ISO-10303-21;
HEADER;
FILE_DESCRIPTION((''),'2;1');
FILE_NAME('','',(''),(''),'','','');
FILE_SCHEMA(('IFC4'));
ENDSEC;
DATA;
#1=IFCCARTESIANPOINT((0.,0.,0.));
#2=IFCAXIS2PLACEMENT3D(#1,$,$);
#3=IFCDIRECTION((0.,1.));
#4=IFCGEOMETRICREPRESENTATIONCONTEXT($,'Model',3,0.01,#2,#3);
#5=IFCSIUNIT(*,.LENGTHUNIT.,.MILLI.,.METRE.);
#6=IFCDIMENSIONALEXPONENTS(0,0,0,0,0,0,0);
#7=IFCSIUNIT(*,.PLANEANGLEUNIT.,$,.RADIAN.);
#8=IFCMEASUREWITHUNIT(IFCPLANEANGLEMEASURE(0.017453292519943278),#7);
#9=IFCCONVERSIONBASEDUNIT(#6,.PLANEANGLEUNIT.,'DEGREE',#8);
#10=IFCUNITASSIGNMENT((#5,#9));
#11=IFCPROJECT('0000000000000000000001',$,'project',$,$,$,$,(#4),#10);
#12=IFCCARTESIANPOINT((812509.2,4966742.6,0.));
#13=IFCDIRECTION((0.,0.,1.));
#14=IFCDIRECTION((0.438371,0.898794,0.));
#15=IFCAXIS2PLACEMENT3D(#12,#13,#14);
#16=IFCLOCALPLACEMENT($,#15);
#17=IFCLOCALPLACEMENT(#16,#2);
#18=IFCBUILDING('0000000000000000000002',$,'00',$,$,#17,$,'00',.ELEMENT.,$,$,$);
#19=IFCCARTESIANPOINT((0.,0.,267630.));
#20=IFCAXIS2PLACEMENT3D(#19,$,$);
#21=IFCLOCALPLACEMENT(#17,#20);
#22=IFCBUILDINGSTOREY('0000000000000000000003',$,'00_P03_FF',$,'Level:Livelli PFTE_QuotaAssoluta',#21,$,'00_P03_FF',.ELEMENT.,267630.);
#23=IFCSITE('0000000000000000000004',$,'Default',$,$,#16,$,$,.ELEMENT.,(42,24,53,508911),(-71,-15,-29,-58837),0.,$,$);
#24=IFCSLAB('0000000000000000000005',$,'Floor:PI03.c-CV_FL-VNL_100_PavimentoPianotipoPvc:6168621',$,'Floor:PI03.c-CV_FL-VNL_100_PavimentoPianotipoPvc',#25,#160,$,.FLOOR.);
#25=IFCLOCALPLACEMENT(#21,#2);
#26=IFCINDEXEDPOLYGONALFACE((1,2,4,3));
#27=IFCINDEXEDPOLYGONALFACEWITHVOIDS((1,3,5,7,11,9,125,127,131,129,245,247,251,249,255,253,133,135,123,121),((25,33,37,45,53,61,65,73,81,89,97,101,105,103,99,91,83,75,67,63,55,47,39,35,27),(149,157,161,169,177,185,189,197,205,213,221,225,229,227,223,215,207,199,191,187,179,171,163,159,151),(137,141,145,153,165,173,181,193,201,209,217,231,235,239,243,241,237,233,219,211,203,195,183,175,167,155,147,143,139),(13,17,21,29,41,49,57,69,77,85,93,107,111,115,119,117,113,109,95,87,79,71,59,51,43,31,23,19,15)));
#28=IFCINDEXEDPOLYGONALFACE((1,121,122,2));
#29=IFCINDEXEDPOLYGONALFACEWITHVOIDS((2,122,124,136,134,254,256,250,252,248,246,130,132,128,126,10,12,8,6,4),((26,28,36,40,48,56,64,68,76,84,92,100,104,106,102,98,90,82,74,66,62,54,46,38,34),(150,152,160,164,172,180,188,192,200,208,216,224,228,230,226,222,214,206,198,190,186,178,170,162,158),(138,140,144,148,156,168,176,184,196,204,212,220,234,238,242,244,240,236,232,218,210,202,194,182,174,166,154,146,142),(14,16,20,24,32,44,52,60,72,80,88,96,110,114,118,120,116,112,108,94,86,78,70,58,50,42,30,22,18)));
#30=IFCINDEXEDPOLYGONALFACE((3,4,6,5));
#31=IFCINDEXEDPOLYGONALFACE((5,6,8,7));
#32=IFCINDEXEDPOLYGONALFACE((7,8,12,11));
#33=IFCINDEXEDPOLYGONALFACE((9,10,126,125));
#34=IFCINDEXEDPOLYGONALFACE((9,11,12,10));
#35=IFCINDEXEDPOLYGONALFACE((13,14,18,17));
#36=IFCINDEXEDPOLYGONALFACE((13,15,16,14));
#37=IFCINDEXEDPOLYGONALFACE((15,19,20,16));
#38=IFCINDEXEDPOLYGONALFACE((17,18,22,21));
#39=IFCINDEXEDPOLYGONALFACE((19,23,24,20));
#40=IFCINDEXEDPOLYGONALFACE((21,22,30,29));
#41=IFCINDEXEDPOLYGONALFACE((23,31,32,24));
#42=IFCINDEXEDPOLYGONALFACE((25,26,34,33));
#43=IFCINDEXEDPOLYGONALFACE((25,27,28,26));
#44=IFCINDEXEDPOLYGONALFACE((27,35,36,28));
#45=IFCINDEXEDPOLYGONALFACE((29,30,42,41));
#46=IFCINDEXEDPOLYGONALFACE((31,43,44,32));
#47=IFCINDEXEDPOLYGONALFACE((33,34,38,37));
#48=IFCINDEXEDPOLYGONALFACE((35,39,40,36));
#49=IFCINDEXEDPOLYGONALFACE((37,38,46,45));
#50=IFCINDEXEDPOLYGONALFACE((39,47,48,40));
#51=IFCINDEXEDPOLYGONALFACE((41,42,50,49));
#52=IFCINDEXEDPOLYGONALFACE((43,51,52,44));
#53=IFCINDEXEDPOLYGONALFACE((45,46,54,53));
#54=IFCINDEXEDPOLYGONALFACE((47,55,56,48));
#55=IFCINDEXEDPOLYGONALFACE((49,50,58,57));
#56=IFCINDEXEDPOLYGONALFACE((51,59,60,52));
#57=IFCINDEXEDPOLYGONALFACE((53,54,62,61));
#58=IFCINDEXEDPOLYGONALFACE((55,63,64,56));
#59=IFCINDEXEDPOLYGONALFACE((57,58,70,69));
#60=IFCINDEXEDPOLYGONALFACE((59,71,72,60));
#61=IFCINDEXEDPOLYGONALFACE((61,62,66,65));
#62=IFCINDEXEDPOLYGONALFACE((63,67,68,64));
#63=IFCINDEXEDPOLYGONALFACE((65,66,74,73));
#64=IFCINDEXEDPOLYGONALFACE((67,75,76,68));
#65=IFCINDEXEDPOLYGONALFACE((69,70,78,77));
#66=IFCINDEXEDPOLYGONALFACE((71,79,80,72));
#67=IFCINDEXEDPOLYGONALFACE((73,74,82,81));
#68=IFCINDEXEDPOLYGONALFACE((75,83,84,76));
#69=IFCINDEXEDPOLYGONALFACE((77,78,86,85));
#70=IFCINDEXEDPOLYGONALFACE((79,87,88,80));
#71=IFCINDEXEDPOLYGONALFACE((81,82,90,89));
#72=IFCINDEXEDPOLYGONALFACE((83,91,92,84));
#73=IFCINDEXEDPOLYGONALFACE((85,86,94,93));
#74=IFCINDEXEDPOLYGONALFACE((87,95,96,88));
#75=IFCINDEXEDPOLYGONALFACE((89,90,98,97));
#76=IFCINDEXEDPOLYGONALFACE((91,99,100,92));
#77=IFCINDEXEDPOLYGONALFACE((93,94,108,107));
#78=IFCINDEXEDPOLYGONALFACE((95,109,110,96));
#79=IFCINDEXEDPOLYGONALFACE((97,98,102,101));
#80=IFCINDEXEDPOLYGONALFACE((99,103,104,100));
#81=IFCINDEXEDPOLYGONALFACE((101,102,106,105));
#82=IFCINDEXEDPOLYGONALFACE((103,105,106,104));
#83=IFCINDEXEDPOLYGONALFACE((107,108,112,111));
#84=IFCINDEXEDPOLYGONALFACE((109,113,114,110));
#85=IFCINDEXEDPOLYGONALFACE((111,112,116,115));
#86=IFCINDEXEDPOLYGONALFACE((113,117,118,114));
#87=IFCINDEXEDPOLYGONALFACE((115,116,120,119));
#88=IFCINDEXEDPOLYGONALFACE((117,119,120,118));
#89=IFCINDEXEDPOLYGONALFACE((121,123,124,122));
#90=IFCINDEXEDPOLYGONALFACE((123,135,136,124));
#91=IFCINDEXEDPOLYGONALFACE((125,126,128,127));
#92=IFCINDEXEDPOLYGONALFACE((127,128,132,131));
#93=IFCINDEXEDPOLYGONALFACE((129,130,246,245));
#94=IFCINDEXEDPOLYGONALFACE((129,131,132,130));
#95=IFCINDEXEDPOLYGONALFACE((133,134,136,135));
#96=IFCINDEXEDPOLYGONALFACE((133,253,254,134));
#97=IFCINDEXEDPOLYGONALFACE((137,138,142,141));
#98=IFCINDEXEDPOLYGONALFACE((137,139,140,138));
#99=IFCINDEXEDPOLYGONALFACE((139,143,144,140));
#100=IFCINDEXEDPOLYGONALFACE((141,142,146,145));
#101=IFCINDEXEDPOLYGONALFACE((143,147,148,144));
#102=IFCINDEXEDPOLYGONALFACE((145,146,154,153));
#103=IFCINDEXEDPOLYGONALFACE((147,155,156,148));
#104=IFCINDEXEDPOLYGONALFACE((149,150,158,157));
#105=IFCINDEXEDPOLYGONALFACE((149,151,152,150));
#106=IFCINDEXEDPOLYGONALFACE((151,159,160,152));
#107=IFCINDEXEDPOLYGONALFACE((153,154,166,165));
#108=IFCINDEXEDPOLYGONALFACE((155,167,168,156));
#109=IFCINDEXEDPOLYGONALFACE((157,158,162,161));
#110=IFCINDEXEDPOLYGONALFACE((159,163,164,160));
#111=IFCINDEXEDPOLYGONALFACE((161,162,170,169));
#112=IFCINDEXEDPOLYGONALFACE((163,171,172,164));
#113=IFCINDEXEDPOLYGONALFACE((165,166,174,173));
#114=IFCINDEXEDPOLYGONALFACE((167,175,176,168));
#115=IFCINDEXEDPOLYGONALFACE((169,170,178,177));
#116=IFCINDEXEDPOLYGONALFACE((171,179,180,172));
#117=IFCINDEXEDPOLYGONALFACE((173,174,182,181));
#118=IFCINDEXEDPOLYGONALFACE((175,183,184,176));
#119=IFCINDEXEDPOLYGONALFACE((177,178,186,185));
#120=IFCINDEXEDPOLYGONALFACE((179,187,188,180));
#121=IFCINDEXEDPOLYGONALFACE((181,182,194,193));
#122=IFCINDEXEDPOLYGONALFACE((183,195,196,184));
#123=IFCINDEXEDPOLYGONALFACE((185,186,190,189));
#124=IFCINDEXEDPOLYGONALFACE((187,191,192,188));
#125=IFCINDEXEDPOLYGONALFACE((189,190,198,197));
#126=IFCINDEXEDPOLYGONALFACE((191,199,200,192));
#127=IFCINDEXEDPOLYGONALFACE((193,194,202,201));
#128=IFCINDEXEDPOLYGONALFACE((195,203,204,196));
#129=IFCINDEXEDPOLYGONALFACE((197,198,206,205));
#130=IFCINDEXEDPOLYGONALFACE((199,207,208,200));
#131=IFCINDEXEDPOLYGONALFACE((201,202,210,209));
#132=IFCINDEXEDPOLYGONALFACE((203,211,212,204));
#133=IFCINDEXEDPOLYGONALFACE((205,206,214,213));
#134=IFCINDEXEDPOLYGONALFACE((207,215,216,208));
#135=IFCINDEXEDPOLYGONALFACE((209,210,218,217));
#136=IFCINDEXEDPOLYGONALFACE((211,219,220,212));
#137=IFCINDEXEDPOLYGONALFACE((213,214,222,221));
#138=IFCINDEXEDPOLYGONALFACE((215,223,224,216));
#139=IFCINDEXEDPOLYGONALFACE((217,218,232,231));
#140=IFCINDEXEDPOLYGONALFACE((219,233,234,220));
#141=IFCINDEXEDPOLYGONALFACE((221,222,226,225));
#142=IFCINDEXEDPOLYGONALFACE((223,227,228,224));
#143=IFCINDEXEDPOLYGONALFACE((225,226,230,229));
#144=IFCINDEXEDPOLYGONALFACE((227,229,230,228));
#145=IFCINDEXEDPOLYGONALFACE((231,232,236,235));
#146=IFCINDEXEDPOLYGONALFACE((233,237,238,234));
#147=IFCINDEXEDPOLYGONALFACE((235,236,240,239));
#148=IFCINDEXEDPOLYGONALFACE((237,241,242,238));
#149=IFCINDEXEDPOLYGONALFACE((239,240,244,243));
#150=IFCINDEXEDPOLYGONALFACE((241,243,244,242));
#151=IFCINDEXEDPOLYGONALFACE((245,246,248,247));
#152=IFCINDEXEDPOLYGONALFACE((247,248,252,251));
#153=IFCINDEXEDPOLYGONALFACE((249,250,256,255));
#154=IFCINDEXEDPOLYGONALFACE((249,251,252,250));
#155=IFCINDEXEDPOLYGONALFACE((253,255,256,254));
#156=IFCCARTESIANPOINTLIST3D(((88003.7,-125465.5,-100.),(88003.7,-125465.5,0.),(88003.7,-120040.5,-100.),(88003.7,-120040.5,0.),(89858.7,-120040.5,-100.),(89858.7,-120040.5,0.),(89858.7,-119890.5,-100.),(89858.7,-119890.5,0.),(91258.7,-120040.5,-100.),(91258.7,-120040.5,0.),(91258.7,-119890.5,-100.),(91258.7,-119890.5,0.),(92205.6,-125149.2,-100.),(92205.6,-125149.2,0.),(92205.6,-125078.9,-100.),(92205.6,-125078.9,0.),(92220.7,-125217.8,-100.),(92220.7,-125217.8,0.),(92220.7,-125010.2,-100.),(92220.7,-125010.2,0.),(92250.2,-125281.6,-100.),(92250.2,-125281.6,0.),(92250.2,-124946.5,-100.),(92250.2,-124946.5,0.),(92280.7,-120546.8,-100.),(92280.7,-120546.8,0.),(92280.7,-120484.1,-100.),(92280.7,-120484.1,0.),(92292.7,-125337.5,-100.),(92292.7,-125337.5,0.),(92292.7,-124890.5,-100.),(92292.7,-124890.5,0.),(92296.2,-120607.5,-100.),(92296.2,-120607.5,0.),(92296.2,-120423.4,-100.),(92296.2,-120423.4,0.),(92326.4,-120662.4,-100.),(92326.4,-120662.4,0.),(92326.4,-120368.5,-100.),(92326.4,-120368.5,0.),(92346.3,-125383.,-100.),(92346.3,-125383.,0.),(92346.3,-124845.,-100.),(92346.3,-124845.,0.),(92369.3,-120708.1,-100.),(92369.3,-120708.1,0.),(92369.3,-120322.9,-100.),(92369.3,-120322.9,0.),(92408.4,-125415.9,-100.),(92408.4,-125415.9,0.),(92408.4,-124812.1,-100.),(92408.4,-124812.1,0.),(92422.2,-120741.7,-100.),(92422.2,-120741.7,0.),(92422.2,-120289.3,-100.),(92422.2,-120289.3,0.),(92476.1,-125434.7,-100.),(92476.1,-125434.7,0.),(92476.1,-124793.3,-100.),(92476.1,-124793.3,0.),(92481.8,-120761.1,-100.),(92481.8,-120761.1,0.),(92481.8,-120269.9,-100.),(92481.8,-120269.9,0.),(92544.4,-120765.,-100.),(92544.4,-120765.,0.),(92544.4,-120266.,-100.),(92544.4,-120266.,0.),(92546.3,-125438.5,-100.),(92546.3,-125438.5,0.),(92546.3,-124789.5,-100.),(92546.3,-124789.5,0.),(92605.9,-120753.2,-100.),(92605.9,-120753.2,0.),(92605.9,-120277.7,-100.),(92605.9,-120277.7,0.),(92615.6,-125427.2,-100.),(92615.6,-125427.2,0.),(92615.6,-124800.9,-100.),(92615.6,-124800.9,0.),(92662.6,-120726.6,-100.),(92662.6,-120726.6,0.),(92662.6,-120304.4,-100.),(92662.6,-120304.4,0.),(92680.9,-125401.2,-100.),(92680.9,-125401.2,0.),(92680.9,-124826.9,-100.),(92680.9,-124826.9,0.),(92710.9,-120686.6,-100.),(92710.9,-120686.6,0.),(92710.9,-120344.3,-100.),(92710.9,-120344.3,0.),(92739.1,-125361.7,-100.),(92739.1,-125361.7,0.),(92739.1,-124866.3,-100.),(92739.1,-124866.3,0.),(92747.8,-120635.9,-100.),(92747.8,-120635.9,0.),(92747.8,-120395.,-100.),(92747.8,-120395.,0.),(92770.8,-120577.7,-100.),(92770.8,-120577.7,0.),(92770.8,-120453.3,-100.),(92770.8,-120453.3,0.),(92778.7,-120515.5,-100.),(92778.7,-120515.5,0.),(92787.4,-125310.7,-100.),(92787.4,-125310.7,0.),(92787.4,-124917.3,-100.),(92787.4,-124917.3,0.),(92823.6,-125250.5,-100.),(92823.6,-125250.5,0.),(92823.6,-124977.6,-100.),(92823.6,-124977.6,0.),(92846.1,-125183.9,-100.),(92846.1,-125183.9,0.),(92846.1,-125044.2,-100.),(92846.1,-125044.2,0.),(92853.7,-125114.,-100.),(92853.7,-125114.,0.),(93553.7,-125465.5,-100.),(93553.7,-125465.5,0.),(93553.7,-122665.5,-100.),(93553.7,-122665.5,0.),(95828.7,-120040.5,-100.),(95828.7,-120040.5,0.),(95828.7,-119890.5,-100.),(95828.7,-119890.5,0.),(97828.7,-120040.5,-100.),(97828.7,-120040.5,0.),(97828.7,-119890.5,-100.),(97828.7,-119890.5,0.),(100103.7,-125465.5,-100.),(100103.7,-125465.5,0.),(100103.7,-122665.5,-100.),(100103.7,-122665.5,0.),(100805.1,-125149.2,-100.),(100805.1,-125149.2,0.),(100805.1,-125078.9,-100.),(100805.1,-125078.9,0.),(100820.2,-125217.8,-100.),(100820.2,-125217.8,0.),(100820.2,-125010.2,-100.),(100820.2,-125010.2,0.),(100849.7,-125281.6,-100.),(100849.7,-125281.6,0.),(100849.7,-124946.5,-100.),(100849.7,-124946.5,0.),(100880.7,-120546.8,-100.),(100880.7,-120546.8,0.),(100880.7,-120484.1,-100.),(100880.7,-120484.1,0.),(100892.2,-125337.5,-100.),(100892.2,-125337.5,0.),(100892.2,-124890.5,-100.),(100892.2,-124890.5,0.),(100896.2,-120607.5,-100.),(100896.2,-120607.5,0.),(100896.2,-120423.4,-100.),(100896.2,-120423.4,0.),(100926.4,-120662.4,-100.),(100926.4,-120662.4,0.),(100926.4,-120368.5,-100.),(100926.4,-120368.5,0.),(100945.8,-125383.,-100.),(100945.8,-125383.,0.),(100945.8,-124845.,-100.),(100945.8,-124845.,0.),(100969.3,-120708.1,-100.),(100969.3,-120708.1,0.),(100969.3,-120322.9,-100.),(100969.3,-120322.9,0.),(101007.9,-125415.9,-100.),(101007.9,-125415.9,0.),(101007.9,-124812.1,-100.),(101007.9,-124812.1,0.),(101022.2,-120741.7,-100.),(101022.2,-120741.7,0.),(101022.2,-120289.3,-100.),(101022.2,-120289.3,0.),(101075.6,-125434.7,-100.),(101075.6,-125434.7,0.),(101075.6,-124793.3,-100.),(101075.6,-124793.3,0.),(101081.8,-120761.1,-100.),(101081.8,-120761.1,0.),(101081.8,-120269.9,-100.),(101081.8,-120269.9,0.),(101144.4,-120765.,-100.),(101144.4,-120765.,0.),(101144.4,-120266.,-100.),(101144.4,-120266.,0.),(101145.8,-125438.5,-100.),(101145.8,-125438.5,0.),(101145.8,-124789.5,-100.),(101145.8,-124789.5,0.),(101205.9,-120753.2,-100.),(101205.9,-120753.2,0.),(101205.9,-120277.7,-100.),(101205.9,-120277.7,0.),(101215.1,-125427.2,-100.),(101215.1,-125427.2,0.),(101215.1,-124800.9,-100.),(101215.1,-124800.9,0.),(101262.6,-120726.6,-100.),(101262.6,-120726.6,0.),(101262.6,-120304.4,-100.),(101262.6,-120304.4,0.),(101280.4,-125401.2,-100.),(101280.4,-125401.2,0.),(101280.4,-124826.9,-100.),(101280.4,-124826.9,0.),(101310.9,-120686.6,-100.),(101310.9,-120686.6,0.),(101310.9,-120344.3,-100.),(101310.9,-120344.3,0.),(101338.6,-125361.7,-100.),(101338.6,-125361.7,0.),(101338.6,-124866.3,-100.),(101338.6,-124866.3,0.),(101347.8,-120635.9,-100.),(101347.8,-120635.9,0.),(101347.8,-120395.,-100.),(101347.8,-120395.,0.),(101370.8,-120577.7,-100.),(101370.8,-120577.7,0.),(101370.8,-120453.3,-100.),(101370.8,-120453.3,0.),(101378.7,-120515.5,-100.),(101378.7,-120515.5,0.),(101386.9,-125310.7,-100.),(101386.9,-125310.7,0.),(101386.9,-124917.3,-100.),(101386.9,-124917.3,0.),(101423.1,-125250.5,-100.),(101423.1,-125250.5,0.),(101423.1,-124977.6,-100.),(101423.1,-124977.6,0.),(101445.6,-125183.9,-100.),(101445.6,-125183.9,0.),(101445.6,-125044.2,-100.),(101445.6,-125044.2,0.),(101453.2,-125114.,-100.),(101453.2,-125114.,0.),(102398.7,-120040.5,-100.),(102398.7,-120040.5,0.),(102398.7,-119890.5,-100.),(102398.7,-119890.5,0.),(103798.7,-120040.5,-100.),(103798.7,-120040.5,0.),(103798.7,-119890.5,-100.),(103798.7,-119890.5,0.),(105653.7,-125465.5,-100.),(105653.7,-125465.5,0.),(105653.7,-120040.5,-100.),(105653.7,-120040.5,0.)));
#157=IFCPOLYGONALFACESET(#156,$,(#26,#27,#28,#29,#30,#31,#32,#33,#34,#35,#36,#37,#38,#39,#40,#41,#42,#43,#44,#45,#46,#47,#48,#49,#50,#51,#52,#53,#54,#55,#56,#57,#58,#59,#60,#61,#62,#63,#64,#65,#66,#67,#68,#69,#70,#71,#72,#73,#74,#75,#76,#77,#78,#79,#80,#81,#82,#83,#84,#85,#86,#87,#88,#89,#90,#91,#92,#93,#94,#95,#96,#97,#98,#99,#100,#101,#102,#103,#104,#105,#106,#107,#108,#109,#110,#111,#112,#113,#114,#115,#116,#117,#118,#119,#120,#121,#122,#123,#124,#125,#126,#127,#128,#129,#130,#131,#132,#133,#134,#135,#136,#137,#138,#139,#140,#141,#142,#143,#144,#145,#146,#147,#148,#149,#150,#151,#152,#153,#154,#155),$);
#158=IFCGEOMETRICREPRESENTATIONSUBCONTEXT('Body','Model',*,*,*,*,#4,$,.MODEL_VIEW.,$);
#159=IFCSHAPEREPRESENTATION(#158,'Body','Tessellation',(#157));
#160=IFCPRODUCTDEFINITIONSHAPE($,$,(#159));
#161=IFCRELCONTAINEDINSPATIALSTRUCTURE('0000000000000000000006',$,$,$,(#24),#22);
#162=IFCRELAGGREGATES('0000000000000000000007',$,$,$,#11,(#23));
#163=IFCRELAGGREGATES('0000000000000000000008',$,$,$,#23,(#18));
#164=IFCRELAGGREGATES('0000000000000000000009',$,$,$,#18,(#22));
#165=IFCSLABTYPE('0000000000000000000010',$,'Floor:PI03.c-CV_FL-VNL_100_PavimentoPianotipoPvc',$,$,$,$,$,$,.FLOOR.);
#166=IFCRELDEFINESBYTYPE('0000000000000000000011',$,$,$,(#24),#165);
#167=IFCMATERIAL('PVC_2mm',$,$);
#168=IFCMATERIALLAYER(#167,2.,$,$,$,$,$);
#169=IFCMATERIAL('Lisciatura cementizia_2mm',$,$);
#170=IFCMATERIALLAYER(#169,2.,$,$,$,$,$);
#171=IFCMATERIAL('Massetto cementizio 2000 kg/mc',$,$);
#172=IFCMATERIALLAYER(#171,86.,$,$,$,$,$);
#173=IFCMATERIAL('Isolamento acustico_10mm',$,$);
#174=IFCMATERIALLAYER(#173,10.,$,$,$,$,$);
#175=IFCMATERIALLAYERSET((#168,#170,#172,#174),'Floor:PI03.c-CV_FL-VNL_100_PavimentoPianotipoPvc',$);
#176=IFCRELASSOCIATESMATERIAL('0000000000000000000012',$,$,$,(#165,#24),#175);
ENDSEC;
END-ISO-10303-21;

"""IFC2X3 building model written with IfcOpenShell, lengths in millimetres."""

from ifc_helpers import new_model, entity, si_unit, converted_unit, direction, frame, frame_2d, origin, origin_2d_with_axis, place, context, subcontext, project, spatial, polyline, circle, outline, extrude, material, layer, layer_set, layer_usage, type_object, element, save


model = new_model("IFC2X3")

# Units and contexts
model_context = context("Model", 3, precision=0.01, world=origin(), true_north=direction((0.0, 1.0)))
body_context = subcontext(model_context, "Body", "Model", "MODEL_VIEW")
ifc_project = project(units=[si_unit("LENGTHUNIT", "METRE", prefix="MILLI"), converted_unit("PLANEANGLEUNIT", "DEGREE", entity("IfcPlaneAngleMeasure", 0.017453292519943278), si_unit("PLANEANGLEUNIT", "RADIAN"), dimensions=[0, 0, 0, 0, 0, 0, 0])], contexts=[model_context])

# Site, building, storey
site_placement = place(None, frame((812509.2, 4966742.6, 0.0), z_axis=(0.0, 0.0, 1.0), x_axis=(0.438371, 0.898794, 0.0)))
site = spatial("IfcSite", under=ifc_project, at=site_placement, Name="Default", CompositionType="ELEMENT", RefLatitude=(42, 24, 53, 508911), RefLongitude=(-71, -15, -29, -58837), RefElevation=0.0)
building_placement = place(site_placement, origin())
building = spatial("IfcBuilding", under=site, at=building_placement, Name="00", LongName="00", CompositionType="ELEMENT")
storey_placement = place(building_placement, frame((0.0, 0.0, 267630.0)))
storey = spatial("IfcBuildingStorey", under=building, at=storey_placement, Name="00_P03_FF", ObjectType="Level:Livelli PFTE_QuotaAssoluta", LongName="00_P03_FF", CompositionType="ELEMENT", Elevation=267630.0)

# Slab, openings
ifc_material_1 = material(Name="Massetto cementizio 2000 kg/mc")
ifc_material_2 = material(Name="Isolamento acustico_10mm")
ifc_material_3 = material(Name="PVC_2mm")
ifc_layer_1 = layer(ifc_material_3, 2.0)
ifc_material_4 = material(Name="Lisciatura cementizia_2mm")
ifc_layer_2 = layer(ifc_material_4, 2.0)
ifc_layer_3 = layer(ifc_material_1, 86.0)
ifc_layer_4 = layer(ifc_material_2, 10.0)
ifc_layer_set_1 = layer_set([ifc_layer_1, ifc_layer_2, ifc_layer_3, ifc_layer_4], Name="Floor:PI03.c-CV_FL-VNL_100_PavimentoPianotipoPvc")
ifc_layer_usage_1 = layer_usage(ifc_layer_set_1, "AXIS3", "POSITIVE", 0.0)
slab_type_1 = type_object("IfcSlabType", Name="Floor:PI03.c-CV_FL-VNL_100_PavimentoPianotipoPvc", PredefinedType="FLOOR", material=ifc_layer_set_1)
slab_1_placement = place(storey_placement, frame((88003.7, -125465.5, -100.0)))
slab_1 = element("IfcSlab", 1, at=slab_1_placement, inside=storey, type_object=slab_type_1, material=ifc_layer_usage_1, Name="Floor:PI03.c-CV_FL-VNL_100_PavimentoPianotipoPvc:6168621", ObjectType="Floor:PI03.c-CV_FL-VNL_100_PavimentoPianotipoPvc", PredefinedType="FLOOR", context=body_context, shape_type="SweptSolid", body=[
    extrude(outline(polyline([(-6970.0, 2637.5), (-8825.0, 2637.5), (-8825.0, -2787.5), (-3275.0, -2787.5), (-3275.0, 12.5), (3275.0, 12.5), (3275.0, -2787.5), (8825.0, -2787.5), (8825.0, 2637.5), (6970.0, 2637.5), (6970.0, 2787.5), (5570.0, 2787.5), (5570.0, 2637.5), (1000.0, 2637.5), (1000.0, 2787.5), (-1000.0, 2787.5), (-1000.0, 2637.5), (-5570.0, 2637.5), (-5570.0, 2787.5), (-6970.0, 2787.5), (-6970.0, 2637.5)])), frame((8825.0, 2787.5, 100.0), z_axis=(0.0, 0.0, -1.0), x_axis=(-1.0, 0.0, 0.0)), (0.0, 0.0, 1.0), 100.0),
])
opening_1_placement = place(slab_1_placement, origin())
element("IfcOpeningElement", 2, at=opening_1_placement, cuts=slab_1, ObjectType="Opening", context=body_context, shape_type="SweptSolid", body=[
    extrude(circle(Radius=250.0, at=frame_2d((0.0, 0.0), x_axis=(1.0, 0.0))), frame((13125.0, 4950.0, 100.0), z_axis=(0.0, 0.0, -1.0), x_axis=(1.0, 0.0, 0.0)), (0.0, 0.0, 1.0), 100.0),
])
opening_2_placement = place(slab_1_placement, origin())
element("IfcOpeningElement", 3, at=opening_2_placement, cuts=slab_1, ObjectType="Opening", context=body_context, shape_type="SweptSolid", body=[
    extrude(circle(Radius=250.0, at=frame_2d((0.0, 0.0), x_axis=(1.0, 0.0))), frame((4525.0, 4950.0, 100.0), z_axis=(0.0, 0.0, -1.0), x_axis=(1.0, 0.0, 0.0)), (0.0, 0.0, 1.0), 100.0),
])
opening_3_placement = place(slab_1_placement, origin())
element("IfcOpeningElement", 4, at=opening_3_placement, cuts=slab_1, ObjectType="Opening", context=body_context, shape_type="SweptSolid", body=[
    extrude(circle(Radius=325.0, at=origin_2d_with_axis()), frame((4525.0, 351.5, 100.0), z_axis=(0.0, 0.0, -1.0), x_axis=(1.0, 0.0, 0.0)), (0.0, 0.0, 1.0), 100.0),
])
opening_4_placement = place(slab_1_placement, origin())
element("IfcOpeningElement", 5, at=opening_4_placement, cuts=slab_1, ObjectType="Opening", context=body_context, shape_type="SweptSolid", body=[
    extrude(circle(Radius=325.0, at=origin_2d_with_axis()), frame((13124.5, 351.5, 100.0), z_axis=(0.0, 0.0, -1.0), x_axis=(1.0, 0.0, 0.0)), (0.0, 0.0, 1.0), 100.0),
])

save(model, "model.ifc")
